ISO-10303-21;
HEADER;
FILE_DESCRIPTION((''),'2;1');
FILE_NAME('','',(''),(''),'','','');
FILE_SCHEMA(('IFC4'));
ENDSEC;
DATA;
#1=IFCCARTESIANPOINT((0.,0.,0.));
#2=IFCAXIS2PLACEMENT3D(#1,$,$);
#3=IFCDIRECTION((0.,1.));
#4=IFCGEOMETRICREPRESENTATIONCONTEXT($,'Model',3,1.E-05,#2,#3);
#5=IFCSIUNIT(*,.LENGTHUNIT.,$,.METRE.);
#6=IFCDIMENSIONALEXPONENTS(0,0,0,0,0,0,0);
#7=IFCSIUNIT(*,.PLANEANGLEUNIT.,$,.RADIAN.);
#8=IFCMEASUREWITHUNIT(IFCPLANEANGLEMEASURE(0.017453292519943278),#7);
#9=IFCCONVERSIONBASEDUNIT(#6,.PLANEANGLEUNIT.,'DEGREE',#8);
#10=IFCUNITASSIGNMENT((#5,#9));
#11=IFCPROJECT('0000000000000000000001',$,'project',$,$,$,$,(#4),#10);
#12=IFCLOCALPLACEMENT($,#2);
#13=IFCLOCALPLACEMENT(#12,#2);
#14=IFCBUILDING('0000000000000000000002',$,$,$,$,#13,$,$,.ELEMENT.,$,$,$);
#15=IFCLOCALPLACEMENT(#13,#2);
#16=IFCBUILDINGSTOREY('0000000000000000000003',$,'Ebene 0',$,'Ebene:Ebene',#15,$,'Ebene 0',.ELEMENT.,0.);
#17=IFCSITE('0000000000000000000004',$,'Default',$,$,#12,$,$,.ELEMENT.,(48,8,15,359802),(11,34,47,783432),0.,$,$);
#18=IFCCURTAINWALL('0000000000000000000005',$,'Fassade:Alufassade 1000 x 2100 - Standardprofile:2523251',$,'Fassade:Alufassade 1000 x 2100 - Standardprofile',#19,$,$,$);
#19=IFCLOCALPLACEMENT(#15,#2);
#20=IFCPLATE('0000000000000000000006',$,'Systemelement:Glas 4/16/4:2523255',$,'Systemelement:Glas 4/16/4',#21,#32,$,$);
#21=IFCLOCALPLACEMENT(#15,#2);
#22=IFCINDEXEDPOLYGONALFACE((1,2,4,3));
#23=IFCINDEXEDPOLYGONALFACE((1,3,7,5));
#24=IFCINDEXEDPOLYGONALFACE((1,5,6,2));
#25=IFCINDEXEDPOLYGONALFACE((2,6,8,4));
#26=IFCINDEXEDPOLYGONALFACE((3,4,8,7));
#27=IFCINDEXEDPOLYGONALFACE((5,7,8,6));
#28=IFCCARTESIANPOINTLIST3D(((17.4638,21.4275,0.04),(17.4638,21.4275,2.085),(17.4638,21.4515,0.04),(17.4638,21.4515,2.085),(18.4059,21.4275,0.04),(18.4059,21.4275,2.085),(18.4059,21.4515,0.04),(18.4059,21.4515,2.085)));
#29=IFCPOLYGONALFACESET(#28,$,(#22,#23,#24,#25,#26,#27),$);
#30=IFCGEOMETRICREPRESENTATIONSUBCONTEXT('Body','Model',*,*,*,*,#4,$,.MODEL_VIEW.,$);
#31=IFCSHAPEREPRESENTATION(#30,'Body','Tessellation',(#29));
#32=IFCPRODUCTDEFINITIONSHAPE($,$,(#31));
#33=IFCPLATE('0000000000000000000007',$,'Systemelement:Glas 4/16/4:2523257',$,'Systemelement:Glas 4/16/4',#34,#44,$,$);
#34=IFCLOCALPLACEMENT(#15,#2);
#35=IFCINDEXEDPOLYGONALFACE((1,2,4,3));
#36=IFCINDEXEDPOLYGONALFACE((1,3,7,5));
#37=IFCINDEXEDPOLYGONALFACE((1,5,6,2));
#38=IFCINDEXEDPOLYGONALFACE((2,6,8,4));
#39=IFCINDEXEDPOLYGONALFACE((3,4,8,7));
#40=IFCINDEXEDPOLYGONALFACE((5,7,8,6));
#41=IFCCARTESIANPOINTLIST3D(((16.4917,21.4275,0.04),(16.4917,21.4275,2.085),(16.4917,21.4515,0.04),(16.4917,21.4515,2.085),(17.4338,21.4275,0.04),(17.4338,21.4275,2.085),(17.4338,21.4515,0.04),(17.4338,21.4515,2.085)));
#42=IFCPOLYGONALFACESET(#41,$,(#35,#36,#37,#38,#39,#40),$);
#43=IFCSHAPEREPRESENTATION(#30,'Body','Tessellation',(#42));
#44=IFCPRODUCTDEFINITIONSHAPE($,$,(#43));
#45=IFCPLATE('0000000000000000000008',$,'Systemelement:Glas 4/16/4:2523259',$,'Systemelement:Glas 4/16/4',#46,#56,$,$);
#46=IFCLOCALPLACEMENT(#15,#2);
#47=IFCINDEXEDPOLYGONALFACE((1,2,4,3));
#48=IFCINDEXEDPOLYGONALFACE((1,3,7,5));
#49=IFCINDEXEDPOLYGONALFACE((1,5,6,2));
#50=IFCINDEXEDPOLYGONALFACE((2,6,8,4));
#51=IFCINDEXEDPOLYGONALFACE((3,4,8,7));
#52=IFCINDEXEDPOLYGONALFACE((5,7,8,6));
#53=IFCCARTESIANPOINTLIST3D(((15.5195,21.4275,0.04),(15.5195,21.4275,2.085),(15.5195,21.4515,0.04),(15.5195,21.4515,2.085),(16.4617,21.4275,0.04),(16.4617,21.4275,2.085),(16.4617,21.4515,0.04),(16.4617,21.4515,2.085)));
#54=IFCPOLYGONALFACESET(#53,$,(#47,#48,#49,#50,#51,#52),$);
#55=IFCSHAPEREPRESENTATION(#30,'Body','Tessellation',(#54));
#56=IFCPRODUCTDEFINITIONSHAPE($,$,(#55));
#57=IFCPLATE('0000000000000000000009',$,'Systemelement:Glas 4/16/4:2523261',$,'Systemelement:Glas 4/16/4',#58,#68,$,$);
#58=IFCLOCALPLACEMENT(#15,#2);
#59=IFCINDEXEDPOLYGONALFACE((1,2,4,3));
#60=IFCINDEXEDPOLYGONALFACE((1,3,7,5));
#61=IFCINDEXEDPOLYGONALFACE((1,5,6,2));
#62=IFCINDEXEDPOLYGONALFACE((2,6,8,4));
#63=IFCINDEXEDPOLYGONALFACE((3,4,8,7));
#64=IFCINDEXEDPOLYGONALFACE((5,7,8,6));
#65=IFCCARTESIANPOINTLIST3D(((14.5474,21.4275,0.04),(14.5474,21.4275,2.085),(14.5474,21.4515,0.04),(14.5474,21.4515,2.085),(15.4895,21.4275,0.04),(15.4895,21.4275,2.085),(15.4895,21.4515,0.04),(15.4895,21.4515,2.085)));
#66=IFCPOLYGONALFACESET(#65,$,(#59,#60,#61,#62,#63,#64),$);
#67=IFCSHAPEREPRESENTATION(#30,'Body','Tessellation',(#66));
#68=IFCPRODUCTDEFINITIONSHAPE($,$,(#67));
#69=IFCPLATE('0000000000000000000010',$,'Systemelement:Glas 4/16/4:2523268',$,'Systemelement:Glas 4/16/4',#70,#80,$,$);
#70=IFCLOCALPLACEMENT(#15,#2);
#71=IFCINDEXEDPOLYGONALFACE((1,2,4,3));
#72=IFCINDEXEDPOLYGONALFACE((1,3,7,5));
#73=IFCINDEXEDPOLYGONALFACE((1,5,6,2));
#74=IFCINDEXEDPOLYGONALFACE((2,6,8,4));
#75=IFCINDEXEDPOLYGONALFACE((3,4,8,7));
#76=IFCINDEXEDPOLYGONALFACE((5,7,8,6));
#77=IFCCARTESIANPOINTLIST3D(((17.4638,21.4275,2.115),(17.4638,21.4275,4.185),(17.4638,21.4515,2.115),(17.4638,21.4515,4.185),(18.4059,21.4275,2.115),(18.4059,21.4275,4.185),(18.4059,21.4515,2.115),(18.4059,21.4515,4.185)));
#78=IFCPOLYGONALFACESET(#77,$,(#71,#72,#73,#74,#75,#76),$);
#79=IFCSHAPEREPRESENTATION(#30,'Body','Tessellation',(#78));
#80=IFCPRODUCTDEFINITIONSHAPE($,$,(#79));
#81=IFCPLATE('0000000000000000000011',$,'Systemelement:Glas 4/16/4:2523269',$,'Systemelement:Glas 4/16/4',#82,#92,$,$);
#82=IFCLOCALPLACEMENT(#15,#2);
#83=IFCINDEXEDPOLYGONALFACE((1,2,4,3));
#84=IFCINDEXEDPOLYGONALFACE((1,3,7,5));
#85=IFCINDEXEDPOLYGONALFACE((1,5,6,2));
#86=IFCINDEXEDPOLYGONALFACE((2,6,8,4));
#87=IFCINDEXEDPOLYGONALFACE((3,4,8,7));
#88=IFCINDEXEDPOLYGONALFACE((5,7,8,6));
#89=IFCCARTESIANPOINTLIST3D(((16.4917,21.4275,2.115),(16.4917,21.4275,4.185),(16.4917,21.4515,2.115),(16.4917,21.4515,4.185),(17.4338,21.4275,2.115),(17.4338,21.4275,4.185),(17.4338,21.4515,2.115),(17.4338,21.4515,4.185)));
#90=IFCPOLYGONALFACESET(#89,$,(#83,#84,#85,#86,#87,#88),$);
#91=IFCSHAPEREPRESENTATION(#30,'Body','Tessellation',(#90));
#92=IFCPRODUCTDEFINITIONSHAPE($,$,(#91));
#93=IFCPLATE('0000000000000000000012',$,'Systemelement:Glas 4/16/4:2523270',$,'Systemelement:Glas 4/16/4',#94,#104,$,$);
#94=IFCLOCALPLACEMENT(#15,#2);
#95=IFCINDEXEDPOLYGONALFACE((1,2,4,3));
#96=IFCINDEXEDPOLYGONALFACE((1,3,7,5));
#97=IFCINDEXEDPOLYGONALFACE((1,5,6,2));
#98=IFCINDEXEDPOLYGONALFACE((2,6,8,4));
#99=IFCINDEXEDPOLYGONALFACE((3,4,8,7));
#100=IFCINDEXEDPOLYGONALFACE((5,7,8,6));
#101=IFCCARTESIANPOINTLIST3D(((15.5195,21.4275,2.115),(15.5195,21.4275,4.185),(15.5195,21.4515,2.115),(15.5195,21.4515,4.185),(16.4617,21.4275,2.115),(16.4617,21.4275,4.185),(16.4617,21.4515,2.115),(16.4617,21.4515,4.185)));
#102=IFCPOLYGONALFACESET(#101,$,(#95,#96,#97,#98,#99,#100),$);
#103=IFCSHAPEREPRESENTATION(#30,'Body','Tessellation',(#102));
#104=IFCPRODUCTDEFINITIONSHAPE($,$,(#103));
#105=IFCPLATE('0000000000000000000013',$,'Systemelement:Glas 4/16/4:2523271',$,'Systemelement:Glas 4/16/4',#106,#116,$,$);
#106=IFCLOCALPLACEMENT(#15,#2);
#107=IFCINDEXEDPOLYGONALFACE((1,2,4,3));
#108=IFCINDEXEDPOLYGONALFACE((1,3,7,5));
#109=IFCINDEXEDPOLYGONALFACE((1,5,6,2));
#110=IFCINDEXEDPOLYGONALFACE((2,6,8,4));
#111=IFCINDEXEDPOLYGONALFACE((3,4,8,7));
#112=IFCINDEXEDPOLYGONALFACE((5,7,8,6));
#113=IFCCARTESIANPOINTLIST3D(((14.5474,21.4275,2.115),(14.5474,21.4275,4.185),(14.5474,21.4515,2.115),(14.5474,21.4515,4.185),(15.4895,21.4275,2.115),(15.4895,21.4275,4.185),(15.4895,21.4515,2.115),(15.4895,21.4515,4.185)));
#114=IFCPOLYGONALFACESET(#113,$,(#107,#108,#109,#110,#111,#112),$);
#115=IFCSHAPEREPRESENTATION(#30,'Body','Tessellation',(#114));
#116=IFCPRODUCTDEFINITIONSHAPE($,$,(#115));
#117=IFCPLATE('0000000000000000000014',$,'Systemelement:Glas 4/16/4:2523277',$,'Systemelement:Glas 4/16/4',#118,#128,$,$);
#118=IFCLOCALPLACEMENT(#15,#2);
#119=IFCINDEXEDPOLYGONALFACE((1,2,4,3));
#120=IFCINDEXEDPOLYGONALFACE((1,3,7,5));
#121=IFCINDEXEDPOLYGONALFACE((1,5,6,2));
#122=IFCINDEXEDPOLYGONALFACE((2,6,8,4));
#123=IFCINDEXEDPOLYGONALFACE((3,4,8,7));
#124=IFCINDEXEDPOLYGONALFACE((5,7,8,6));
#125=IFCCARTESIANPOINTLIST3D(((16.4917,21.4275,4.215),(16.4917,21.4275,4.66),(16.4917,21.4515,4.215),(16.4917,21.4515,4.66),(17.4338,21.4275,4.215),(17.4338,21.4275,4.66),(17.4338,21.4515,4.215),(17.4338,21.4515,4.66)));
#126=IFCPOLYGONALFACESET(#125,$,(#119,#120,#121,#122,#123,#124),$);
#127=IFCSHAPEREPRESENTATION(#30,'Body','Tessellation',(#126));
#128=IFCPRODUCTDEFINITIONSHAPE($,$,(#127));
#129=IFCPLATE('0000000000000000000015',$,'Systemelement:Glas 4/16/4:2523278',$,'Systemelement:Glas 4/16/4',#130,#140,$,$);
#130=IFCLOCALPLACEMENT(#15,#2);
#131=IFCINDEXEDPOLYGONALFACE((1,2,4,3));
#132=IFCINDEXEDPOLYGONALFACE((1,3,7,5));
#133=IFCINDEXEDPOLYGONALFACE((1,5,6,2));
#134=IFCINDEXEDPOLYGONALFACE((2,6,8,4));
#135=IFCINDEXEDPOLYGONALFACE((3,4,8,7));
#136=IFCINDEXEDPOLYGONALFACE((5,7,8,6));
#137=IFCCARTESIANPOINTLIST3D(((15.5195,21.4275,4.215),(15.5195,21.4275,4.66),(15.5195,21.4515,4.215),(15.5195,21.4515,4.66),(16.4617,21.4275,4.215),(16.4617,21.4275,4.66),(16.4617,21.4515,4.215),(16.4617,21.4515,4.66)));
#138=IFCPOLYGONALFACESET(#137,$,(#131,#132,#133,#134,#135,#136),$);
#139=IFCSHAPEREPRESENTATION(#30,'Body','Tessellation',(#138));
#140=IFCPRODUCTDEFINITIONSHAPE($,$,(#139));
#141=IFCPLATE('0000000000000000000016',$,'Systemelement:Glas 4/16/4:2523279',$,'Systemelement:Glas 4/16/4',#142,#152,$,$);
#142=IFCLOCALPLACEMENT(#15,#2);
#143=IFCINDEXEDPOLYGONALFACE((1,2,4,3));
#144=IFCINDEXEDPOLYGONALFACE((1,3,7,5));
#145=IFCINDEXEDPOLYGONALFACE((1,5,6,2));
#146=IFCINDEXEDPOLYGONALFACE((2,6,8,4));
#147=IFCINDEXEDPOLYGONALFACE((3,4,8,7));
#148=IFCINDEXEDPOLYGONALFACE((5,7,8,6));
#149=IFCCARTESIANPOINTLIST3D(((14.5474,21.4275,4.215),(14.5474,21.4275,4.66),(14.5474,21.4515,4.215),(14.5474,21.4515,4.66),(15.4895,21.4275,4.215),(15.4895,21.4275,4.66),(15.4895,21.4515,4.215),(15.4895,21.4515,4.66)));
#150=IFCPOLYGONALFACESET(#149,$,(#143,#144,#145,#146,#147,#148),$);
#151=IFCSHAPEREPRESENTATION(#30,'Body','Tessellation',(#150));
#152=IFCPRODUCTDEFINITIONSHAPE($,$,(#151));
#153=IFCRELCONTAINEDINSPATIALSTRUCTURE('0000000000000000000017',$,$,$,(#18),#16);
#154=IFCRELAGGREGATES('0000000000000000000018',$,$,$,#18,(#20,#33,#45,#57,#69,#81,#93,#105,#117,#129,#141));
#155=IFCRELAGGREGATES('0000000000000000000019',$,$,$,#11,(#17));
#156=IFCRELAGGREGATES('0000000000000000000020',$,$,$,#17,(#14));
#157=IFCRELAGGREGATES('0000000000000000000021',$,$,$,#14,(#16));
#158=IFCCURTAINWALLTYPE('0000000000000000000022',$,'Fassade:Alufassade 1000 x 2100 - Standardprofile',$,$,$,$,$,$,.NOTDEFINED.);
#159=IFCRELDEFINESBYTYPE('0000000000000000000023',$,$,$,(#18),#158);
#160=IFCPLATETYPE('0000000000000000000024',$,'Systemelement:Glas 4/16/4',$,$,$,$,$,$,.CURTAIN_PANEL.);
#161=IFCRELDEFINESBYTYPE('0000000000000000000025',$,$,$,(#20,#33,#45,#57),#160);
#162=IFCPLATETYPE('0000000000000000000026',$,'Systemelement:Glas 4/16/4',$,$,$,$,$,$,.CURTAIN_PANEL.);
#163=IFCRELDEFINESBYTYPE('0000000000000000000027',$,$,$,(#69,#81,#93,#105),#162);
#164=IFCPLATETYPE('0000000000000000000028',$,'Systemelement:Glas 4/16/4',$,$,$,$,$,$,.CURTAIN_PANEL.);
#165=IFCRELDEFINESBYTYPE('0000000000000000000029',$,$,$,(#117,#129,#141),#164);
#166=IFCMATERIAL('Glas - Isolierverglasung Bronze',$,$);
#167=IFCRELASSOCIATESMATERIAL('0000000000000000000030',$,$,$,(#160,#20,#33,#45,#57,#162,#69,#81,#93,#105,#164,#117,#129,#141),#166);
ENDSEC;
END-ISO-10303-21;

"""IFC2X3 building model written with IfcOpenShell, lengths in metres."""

from ifc_helpers import new_model, entity, si_unit, converted_unit, direction, frame, origin, origin_2d_with_axis, place, context, subcontext, project, spatial, rectangle, extrude, source, transform, mapped, material, type_object, type_shapes, element, aggregate, save


model = new_model("IFC2X3")

# Units and contexts
model_context = context("Model", 3, precision=1e-05, world=origin(), true_north=direction((0.0, 1.0)))
body_context = subcontext(model_context, "Body", "Model", "MODEL_VIEW")
ifc_project = project(units=[si_unit("LENGTHUNIT", "METRE"), converted_unit("PLANEANGLEUNIT", "DEGREE", entity("IfcPlaneAngleMeasure", 0.017453292519943278), si_unit("PLANEANGLEUNIT", "RADIAN"), dimensions=[0, 0, 0, 0, 0, 0, 0])], contexts=[model_context])

# Site, building, storey
site_placement = place(None, origin())
site = spatial("IfcSite", under=ifc_project, at=site_placement, Name="Default", CompositionType="ELEMENT", RefLatitude=(48, 8, 15, 359802), RefLongitude=(11, 34, 47, 783432), RefElevation=0.0)
building_placement = place(site_placement, origin())
building = spatial("IfcBuilding", under=site, at=building_placement, CompositionType="ELEMENT")
storey_placement = place(building_placement, origin())
storey = spatial("IfcBuildingStorey", under=building, at=storey_placement, Name="Ebene 0", ObjectType="Ebene:Ebene", LongName="Ebene 0", CompositionType="ELEMENT", Elevation=0.0)

# Curtain wall, plates
curtain_wall_type = type_object("IfcCurtainWallType", Name="Fassade:Alufassade 1000 x 2100 - Standardprofile", PredefinedType="NOTDEFINED")
curtain_wall_placement = place(storey_placement, origin())
curtain_wall = element("IfcCurtainWall", 1, at=curtain_wall_placement, inside=storey, type_object=curtain_wall_type, Name="Fassade:Alufassade 1000 x 2100 - Standardprofile:2523251", ObjectType="Fassade:Alufassade 1000 x 2100 - Standardprofile")
ifc_material_1 = material(Name="Glas - Isolierverglasung Bronze")
plate_type_1 = type_object("IfcPlateType", Name="Systemelement:Glas 4/16/4", PredefinedType="CURTAIN_PANEL", material=ifc_material_1)
shared_shape_1 = source(origin(), body_context, "Body", "SweptSolid", [
    extrude(rectangle(XDim=0.024, YDim=0.9421, at=origin_2d_with_axis()), frame((0.0, 0.0, 0.0), z_axis=(0.0, 0.0, 1.0), x_axis=(0.0, 1.0, 0.0)), (0.0, 0.0, 1.0), 2.045),
])
type_shapes(plate_type_1, [shared_shape_1])
plate_1_placement = place(curtain_wall_placement, frame((17.9349, 21.4395, 0.04), z_axis=(0.0, 0.0, 1.0), x_axis=(-1.0, 0.0, 0.0)))
plate_1 = element("IfcPlate", 2, at=plate_1_placement, type_object=plate_type_1, material=ifc_material_1, Name="Systemelement:Glas 4/16/4:2523255", ObjectType="Systemelement:Glas 4/16/4", context=body_context, shape_type="MappedRepresentation", body=[
    mapped(shared_shape_1, transform((0.0, 0.0, 0.0), scale=1.0)),
])
plate_2_placement = place(curtain_wall_placement, frame((16.9627, 21.4395, 0.04), z_axis=(0.0, 0.0, 1.0), x_axis=(-1.0, 0.0, 0.0)))
plate_2 = element("IfcPlate", 3, at=plate_2_placement, type_object=plate_type_1, material=ifc_material_1, Name="Systemelement:Glas 4/16/4:2523257", ObjectType="Systemelement:Glas 4/16/4", context=body_context, shape_type="MappedRepresentation", body=[
    mapped(shared_shape_1, transform((0.0, 0.0, 0.0), scale=1.0)),
])
plate_3_placement = place(curtain_wall_placement, frame((15.9906, 21.4395, 0.04), z_axis=(0.0, 0.0, 1.0), x_axis=(-1.0, 0.0, 0.0)))
plate_3 = element("IfcPlate", 4, at=plate_3_placement, type_object=plate_type_1, material=ifc_material_1, Name="Systemelement:Glas 4/16/4:2523259", ObjectType="Systemelement:Glas 4/16/4", context=body_context, shape_type="MappedRepresentation", body=[
    mapped(shared_shape_1, transform((0.0, 0.0, 0.0), scale=1.0)),
])
plate_4_placement = place(curtain_wall_placement, frame((15.0184, 21.4395, 0.04), z_axis=(0.0, 0.0, 1.0), x_axis=(-1.0, 0.0, 0.0)))
plate_4 = element("IfcPlate", 5, at=plate_4_placement, type_object=plate_type_1, material=ifc_material_1, Name="Systemelement:Glas 4/16/4:2523261", ObjectType="Systemelement:Glas 4/16/4", context=body_context, shape_type="MappedRepresentation", body=[
    mapped(shared_shape_1, transform((0.0, 0.0, 0.0), scale=1.0)),
])
plate_type_2 = type_object("IfcPlateType", Name="Systemelement:Glas 4/16/4", PredefinedType="CURTAIN_PANEL", material=ifc_material_1)
shared_shape_2 = source(origin(), body_context, "Body", "SweptSolid", [
    extrude(rectangle(XDim=0.024, YDim=0.9421, at=origin_2d_with_axis()), frame((0.0, 0.0, 0.0), z_axis=(0.0, 0.0, 1.0), x_axis=(0.0, 1.0, 0.0)), (0.0, 0.0, 1.0), 2.07),
])
type_shapes(plate_type_2, [shared_shape_2])
plate_5_placement = place(curtain_wall_placement, frame((17.9349, 21.4395, 2.115), z_axis=(0.0, 0.0, 1.0), x_axis=(-1.0, 0.0, 0.0)))
plate_5 = element("IfcPlate", 6, at=plate_5_placement, type_object=plate_type_2, material=ifc_material_1, Name="Systemelement:Glas 4/16/4:2523268", ObjectType="Systemelement:Glas 4/16/4", context=body_context, shape_type="MappedRepresentation", body=[
    mapped(shared_shape_2, transform((0.0, 0.0, 0.0), scale=1.0)),
])
plate_6_placement = place(curtain_wall_placement, frame((16.9627, 21.4395, 2.115), z_axis=(0.0, 0.0, 1.0), x_axis=(-1.0, 0.0, 0.0)))
plate_6 = element("IfcPlate", 7, at=plate_6_placement, type_object=plate_type_2, material=ifc_material_1, Name="Systemelement:Glas 4/16/4:2523269", ObjectType="Systemelement:Glas 4/16/4", context=body_context, shape_type="MappedRepresentation", body=[
    mapped(shared_shape_2, transform((0.0, 0.0, 0.0), scale=1.0)),
])
plate_7_placement = place(curtain_wall_placement, frame((15.9906, 21.4395, 2.115), z_axis=(0.0, 0.0, 1.0), x_axis=(-1.0, 0.0, 0.0)))
plate_7 = element("IfcPlate", 8, at=plate_7_placement, type_object=plate_type_2, material=ifc_material_1, Name="Systemelement:Glas 4/16/4:2523270", ObjectType="Systemelement:Glas 4/16/4", context=body_context, shape_type="MappedRepresentation", body=[
    mapped(shared_shape_2, transform((0.0, 0.0, 0.0), scale=1.0)),
])
plate_8_placement = place(curtain_wall_placement, frame((15.0184, 21.4395, 2.115), z_axis=(0.0, 0.0, 1.0), x_axis=(-1.0, 0.0, 0.0)))
plate_8 = element("IfcPlate", 9, at=plate_8_placement, type_object=plate_type_2, material=ifc_material_1, Name="Systemelement:Glas 4/16/4:2523271", ObjectType="Systemelement:Glas 4/16/4", context=body_context, shape_type="MappedRepresentation", body=[
    mapped(shared_shape_2, transform((0.0, 0.0, 0.0), scale=1.0)),
])
plate_type_3 = type_object("IfcPlateType", Name="Systemelement:Glas 4/16/4", PredefinedType="CURTAIN_PANEL", material=ifc_material_1)
shared_shape_3 = source(origin(), body_context, "Body", "SweptSolid", [
    extrude(rectangle(XDim=0.024, YDim=0.9421, at=origin_2d_with_axis()), frame((0.0, 0.0, 0.0), z_axis=(0.0, 0.0, 1.0), x_axis=(0.0, 1.0, 0.0)), (0.0, 0.0, 1.0), 0.445),
])
type_shapes(plate_type_3, [shared_shape_3])
plate_9_placement = place(curtain_wall_placement, frame((16.9627, 21.4395, 4.215), z_axis=(0.0, 0.0, 1.0), x_axis=(-1.0, 0.0, 0.0)))
plate_9 = element("IfcPlate", 10, at=plate_9_placement, type_object=plate_type_3, material=ifc_material_1, Name="Systemelement:Glas 4/16/4:2523277", ObjectType="Systemelement:Glas 4/16/4", context=body_context, shape_type="MappedRepresentation", body=[
    mapped(shared_shape_3, transform((0.0, 0.0, 0.0), scale=1.0)),
])
plate_10_placement = place(curtain_wall_placement, frame((15.9906, 21.4395, 4.215), z_axis=(0.0, 0.0, 1.0), x_axis=(-1.0, 0.0, 0.0)))
plate_10 = element("IfcPlate", 11, at=plate_10_placement, type_object=plate_type_3, material=ifc_material_1, Name="Systemelement:Glas 4/16/4:2523278", ObjectType="Systemelement:Glas 4/16/4", context=body_context, shape_type="MappedRepresentation", body=[
    mapped(shared_shape_3, transform((0.0, 0.0, 0.0), scale=1.0)),
])
plate_11_placement = place(curtain_wall_placement, frame((15.0184, 21.4395, 4.215), z_axis=(0.0, 0.0, 1.0), x_axis=(-1.0, 0.0, 0.0)))
plate_11 = element("IfcPlate", 12, at=plate_11_placement, type_object=plate_type_3, material=ifc_material_1, Name="Systemelement:Glas 4/16/4:2523279", ObjectType="Systemelement:Glas 4/16/4", context=body_context, shape_type="MappedRepresentation", body=[
    mapped(shared_shape_3, transform((0.0, 0.0, 0.0), scale=1.0)),
])
aggregate(curtain_wall, [plate_1, plate_2, plate_3, plate_4, plate_5, plate_6, plate_7, plate_8, plate_9, plate_10, plate_11])

save(model, "model.ifc")
